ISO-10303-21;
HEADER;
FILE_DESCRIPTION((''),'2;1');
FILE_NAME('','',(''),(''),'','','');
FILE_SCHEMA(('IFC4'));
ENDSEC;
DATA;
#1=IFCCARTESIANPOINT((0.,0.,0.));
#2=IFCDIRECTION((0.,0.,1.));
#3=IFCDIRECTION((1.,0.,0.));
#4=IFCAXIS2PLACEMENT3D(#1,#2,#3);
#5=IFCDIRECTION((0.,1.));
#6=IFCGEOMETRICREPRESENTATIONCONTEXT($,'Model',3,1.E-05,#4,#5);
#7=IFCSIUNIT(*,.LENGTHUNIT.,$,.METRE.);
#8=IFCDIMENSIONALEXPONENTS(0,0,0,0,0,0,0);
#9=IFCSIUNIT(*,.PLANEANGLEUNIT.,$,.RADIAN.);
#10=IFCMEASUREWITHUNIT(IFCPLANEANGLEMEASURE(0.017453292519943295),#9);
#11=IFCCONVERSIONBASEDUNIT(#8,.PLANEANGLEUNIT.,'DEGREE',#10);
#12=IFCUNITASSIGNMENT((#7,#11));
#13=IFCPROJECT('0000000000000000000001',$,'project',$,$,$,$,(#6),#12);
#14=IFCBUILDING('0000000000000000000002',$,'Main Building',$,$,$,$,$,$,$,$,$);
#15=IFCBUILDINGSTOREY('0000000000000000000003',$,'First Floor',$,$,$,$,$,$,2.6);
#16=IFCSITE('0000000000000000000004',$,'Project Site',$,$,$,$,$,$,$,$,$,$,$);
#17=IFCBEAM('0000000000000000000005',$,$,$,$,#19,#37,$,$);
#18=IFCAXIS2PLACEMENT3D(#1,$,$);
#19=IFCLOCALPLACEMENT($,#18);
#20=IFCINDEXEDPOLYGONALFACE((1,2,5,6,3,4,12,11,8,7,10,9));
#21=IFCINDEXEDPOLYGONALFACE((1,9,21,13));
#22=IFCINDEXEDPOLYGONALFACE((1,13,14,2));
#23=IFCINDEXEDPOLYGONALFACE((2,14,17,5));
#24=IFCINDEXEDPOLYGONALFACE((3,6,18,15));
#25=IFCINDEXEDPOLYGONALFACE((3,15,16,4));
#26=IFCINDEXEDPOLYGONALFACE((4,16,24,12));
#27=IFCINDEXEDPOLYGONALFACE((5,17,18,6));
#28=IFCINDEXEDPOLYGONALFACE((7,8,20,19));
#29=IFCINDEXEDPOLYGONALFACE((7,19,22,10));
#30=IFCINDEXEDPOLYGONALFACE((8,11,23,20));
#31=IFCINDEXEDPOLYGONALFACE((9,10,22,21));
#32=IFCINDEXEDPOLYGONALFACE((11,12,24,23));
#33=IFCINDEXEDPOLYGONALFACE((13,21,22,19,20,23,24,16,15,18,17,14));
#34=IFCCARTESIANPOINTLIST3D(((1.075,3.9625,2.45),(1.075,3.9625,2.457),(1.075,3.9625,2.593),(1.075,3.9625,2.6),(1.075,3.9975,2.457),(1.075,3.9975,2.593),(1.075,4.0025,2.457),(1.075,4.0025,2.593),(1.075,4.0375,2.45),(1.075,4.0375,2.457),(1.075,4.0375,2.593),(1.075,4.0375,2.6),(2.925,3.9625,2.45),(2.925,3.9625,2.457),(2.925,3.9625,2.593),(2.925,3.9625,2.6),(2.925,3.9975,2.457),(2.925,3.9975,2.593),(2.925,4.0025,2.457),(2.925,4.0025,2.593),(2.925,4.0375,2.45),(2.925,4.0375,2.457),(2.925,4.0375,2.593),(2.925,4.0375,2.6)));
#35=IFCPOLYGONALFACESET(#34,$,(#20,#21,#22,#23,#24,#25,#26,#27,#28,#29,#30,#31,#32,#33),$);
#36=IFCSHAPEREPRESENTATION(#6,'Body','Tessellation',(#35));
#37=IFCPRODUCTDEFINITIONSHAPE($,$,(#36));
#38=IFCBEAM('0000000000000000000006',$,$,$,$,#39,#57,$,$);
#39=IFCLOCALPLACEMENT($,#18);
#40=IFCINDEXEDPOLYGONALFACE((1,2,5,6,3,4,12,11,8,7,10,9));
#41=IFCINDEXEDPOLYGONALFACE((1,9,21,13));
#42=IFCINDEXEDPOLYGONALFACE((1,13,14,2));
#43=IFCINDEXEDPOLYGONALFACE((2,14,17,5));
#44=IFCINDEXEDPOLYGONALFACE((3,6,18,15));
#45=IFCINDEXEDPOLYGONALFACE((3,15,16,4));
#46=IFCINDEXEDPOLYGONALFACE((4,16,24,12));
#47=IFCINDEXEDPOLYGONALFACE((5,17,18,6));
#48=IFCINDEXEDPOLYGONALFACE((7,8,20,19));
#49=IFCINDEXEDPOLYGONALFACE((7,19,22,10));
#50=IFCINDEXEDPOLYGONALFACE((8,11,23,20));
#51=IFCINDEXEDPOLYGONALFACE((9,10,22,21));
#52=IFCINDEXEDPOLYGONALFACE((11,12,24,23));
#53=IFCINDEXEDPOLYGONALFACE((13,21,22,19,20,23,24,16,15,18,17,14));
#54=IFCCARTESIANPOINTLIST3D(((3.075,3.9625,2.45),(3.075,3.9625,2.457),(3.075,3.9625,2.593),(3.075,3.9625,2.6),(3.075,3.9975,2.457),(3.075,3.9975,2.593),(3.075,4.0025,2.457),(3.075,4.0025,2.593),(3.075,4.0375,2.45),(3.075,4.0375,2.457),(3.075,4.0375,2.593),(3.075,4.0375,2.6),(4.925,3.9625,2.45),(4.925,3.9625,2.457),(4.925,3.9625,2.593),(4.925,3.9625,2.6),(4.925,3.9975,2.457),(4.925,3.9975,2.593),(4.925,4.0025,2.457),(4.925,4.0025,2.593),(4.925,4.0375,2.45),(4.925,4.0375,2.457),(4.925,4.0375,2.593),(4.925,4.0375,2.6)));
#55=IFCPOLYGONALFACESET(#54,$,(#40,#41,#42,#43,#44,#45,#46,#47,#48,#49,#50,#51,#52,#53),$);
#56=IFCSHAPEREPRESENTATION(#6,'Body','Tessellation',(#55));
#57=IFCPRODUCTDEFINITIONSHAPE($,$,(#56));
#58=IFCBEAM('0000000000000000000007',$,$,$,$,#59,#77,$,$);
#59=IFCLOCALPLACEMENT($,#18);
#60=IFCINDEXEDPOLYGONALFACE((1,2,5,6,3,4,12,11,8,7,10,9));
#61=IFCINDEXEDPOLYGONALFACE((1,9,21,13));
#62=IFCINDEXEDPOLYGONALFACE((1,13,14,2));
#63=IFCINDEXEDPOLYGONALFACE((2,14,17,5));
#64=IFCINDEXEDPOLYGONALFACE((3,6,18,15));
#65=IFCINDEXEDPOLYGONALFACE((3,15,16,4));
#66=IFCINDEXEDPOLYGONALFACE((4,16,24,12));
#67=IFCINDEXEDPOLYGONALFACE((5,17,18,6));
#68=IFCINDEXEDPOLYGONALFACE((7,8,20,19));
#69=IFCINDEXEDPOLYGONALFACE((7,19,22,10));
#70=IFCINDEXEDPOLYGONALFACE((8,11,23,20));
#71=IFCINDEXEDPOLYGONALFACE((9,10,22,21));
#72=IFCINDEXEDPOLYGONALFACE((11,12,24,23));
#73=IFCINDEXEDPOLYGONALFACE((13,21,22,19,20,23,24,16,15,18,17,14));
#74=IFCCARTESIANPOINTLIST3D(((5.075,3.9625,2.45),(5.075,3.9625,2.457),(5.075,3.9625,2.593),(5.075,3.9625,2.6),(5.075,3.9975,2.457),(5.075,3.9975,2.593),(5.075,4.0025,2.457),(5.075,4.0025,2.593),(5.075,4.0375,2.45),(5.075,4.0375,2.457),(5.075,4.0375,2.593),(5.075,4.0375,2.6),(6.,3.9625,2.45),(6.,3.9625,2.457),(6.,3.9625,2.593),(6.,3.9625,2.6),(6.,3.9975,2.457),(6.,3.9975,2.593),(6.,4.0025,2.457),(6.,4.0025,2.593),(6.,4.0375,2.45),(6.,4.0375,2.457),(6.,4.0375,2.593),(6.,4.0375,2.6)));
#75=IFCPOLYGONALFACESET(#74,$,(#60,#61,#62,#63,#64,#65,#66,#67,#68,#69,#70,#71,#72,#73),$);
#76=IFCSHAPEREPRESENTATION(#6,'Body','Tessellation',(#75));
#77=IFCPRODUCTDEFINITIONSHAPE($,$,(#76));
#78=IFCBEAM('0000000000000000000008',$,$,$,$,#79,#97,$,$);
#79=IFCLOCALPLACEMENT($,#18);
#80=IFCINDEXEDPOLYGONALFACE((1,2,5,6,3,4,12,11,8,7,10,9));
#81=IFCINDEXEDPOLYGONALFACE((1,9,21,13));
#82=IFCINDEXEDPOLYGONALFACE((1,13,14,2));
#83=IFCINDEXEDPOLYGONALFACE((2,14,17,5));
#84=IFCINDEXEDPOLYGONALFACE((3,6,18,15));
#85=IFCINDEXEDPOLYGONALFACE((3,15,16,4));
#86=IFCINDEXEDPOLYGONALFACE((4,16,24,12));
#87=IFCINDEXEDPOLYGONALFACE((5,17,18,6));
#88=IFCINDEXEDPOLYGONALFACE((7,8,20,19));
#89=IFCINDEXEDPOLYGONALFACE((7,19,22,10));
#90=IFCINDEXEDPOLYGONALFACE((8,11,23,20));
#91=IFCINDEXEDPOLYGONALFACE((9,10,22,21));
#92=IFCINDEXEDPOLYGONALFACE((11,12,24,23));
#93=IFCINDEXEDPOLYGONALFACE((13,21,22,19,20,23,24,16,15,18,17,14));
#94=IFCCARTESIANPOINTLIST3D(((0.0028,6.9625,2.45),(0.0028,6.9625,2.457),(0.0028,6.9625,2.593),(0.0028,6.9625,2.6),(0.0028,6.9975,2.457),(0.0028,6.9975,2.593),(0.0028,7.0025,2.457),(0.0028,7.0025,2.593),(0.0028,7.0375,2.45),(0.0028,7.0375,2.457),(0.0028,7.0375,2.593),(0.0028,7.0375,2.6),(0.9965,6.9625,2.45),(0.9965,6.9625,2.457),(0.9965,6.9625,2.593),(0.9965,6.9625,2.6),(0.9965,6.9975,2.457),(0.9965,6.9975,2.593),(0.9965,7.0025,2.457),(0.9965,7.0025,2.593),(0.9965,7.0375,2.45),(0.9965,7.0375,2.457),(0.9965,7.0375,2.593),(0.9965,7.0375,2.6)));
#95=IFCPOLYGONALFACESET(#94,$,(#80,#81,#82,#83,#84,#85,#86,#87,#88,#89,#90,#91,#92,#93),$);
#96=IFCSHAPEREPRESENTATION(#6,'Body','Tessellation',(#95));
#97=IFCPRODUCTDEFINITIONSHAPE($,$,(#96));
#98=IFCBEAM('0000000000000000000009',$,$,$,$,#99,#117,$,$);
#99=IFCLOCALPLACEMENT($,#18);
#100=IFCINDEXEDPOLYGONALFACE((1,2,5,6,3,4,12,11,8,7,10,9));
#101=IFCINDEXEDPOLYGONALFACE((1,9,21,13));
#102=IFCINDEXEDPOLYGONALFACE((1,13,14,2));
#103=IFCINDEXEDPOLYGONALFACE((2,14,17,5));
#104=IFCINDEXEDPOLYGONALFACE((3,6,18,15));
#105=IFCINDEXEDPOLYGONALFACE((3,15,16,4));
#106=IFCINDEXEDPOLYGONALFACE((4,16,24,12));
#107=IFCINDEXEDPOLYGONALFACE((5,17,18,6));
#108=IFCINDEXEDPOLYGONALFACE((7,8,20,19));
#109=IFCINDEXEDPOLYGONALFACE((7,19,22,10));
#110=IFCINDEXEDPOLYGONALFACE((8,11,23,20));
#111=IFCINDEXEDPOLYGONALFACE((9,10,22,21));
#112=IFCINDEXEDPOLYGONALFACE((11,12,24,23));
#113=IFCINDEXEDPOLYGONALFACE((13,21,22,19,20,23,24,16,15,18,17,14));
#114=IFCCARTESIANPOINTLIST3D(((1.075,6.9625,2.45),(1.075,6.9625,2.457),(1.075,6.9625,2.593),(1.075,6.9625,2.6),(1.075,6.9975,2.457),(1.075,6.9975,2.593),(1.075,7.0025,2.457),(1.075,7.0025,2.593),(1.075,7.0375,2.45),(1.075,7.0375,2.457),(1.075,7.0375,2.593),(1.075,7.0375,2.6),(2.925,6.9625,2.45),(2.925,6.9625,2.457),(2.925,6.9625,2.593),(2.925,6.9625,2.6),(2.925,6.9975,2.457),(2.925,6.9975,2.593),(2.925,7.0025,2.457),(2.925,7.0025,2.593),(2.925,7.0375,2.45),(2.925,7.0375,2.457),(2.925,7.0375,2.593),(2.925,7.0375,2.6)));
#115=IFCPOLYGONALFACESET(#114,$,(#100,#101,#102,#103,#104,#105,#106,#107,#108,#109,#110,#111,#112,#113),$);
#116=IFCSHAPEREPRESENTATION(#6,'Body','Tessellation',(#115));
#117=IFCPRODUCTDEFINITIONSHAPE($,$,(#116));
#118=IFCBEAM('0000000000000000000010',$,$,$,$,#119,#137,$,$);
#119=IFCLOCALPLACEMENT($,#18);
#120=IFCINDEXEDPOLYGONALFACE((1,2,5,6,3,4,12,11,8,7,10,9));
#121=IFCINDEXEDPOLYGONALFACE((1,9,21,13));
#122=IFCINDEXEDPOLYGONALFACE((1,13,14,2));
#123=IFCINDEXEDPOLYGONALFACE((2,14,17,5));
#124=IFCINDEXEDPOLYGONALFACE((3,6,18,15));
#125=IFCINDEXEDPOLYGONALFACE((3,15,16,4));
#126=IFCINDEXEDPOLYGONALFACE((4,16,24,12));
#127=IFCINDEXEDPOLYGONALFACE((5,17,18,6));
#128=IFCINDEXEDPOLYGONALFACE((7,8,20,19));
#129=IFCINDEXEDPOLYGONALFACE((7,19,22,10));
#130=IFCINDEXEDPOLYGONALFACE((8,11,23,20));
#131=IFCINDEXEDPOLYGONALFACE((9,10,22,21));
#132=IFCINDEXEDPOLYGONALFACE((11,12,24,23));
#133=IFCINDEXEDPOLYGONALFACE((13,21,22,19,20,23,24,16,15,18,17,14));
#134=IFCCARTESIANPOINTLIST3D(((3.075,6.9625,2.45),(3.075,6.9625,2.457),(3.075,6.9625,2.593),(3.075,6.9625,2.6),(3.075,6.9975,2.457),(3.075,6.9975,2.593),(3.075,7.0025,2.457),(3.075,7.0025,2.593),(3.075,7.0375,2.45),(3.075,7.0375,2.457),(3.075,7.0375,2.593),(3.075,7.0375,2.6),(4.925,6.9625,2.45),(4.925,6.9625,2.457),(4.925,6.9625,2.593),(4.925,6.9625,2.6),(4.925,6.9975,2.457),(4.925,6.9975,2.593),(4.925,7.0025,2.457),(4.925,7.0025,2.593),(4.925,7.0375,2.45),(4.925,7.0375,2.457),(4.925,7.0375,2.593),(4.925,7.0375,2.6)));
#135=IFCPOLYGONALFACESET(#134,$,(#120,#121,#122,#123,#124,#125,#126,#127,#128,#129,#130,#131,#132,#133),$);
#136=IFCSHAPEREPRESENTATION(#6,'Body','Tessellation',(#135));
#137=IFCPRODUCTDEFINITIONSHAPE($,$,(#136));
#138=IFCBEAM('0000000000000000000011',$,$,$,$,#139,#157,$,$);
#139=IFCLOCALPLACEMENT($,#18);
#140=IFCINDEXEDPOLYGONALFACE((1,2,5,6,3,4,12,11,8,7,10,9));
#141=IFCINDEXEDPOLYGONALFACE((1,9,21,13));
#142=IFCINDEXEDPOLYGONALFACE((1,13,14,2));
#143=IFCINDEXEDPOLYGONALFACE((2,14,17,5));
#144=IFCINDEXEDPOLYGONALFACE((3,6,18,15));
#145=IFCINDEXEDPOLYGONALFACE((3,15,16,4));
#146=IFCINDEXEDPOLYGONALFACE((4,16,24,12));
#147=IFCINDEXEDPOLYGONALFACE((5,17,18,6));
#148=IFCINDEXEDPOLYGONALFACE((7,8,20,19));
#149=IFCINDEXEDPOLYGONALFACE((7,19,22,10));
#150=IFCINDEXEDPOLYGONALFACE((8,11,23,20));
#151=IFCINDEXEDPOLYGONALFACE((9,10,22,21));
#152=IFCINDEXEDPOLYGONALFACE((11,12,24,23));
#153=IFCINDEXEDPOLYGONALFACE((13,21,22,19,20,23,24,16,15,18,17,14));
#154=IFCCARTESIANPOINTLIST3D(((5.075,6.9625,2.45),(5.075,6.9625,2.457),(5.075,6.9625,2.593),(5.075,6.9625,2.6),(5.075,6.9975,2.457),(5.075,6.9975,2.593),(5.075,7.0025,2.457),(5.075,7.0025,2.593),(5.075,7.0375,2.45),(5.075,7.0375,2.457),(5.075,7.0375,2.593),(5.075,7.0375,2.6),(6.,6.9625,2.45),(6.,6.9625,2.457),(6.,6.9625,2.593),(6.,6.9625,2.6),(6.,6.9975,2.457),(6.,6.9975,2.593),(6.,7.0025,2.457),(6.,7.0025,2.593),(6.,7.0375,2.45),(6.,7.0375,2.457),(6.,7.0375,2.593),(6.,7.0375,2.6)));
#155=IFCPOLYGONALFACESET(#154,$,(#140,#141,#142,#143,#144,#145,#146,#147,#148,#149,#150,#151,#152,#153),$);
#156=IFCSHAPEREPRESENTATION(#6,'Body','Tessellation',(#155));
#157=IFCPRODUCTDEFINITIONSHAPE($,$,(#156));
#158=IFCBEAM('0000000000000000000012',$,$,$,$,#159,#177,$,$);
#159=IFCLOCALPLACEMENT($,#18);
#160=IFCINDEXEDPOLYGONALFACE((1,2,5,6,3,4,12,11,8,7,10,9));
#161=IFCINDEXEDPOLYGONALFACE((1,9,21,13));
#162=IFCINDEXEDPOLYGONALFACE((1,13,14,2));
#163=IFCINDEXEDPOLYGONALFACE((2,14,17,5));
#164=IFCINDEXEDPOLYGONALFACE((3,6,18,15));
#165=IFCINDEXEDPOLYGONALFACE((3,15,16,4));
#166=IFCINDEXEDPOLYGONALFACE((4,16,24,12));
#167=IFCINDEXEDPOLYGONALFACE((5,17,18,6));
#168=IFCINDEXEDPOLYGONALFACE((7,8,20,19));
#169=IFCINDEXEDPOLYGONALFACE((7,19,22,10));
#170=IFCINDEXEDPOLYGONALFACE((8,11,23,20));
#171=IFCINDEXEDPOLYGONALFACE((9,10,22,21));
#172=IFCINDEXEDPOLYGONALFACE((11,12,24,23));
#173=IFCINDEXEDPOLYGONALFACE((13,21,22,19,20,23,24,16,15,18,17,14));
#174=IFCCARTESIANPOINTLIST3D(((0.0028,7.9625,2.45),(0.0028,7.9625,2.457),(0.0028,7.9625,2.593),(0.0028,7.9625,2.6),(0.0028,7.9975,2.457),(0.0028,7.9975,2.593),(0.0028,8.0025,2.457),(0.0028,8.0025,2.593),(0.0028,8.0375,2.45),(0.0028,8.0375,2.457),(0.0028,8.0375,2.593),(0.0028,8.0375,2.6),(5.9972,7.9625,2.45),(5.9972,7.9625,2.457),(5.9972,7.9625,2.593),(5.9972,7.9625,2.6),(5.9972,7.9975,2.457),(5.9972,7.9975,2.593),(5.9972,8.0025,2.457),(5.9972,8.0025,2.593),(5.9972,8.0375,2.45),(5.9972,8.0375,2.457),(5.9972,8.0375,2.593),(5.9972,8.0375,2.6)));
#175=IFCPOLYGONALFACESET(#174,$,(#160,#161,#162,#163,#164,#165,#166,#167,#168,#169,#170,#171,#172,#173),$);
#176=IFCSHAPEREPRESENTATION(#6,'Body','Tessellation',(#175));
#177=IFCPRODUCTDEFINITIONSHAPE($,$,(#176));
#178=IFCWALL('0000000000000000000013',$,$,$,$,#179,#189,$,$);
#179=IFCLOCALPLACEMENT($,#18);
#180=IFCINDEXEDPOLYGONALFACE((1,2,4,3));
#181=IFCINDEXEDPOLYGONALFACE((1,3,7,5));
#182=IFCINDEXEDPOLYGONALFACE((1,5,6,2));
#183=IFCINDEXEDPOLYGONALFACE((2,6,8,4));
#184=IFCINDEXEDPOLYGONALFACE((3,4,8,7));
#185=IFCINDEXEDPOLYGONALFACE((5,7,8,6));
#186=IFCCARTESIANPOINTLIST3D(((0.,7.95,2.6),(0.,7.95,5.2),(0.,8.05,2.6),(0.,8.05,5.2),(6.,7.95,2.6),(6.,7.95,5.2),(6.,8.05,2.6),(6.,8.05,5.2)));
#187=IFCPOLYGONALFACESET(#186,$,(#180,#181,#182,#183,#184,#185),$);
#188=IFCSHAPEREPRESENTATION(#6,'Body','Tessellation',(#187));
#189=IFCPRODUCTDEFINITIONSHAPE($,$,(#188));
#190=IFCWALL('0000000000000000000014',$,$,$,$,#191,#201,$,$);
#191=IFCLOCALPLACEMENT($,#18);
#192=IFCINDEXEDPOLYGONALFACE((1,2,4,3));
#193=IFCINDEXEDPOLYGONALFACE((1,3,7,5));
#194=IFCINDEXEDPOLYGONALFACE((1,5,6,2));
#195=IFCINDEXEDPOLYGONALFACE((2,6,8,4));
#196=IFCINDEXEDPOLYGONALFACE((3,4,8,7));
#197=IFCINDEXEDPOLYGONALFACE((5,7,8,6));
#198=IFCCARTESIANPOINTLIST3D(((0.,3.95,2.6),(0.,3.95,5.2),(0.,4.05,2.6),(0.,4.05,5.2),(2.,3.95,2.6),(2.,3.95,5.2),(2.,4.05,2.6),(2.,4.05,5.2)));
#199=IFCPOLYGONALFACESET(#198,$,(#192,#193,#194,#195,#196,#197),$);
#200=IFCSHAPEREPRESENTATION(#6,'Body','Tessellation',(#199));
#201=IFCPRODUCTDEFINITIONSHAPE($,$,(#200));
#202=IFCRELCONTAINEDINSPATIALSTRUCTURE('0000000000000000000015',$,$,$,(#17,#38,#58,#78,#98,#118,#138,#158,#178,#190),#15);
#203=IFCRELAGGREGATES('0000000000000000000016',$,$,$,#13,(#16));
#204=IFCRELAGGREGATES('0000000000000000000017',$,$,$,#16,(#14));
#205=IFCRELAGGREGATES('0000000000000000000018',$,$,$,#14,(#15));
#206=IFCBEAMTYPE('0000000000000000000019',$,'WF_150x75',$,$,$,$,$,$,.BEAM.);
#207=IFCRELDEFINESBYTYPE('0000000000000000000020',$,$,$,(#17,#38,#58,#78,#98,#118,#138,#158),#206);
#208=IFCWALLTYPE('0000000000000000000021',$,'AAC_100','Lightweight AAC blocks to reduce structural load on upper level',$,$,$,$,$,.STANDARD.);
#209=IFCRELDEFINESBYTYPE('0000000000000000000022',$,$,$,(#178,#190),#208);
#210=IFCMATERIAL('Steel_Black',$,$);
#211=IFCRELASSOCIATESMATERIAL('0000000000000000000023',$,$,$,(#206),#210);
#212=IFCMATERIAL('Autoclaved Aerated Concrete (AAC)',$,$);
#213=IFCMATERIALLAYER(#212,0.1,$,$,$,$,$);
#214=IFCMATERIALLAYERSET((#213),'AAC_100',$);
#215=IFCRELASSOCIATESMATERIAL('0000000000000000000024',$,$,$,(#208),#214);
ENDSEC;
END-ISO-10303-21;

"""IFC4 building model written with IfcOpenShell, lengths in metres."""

from ifc_helpers import new_model, entity, si_unit, converted_unit, direction, frame, frame_2d, origin, origin_with_axes, origin_2d, place, context, project, spatial, rectangle, i_section, extrude, material, layer, layer_set, material_profile, profile_set, type_object, element, save


model = new_model("IFC4")

# Units and contexts
model_context = context("Model", 3, precision=1e-05, world=origin_with_axes(), true_north=direction((0.0, 1.0)))
ifc_project = project(units=[si_unit("LENGTHUNIT", "METRE"), converted_unit("PLANEANGLEUNIT", "DEGREE", entity("IfcPlaneAngleMeasure", 0.017453292519943295), si_unit("PLANEANGLEUNIT", "RADIAN"), dimensions=[0, 0, 0, 0, 0, 0, 0])], contexts=[model_context])

# Site, building, storey
site = spatial("IfcSite", under=ifc_project, Name="Project Site")
building = spatial("IfcBuilding", under=site, Name="Main Building")
storey = spatial("IfcBuildingStorey", under=building, Name="First Floor", Elevation=2.6)

# Shared definitions
ifc_material_1 = material(Name="Steel_Black")

# Beams
ifc_material_profile_1 = material_profile(ifc_material_1, i_section(OverallWidth=0.075, OverallDepth=0.15, WebThickness=0.005, FlangeThickness=0.007, at=origin_2d()), Name="WF_150x75")
ifc_profile_set_1 = profile_set([ifc_material_profile_1], Name="WF_150x75")
beam_type_1 = type_object("IfcBeamType", Name="WF_150x75", PredefinedType="BEAM", material=ifc_profile_set_1)
for number, where, z_axis, x_axis in (
    (1, (1.075, 4.0, 2.45), (0.0, 0.0, 1.0), (1.0, 0.0, 0.0)),
    (2, (3.075, 4.0, 2.45), (0.0, 0.0, 1.0), (1.0, 0.0, 0.0)),
):
    element("IfcBeam", number, at=place(None, frame(where, z_axis=z_axis, x_axis=x_axis)), inside=storey, type_object=beam_type_1, context=model_context, shape_type="SweptSolid", body=[
        extrude(i_section(OverallWidth=0.075, OverallDepth=0.15, WebThickness=0.005, FlangeThickness=0.007, at=frame_2d((0.0, 0.075))), frame((0.0, 0.0, 0.0), z_axis=(1.0, 0.0, 0.0), x_axis=(0.0, 1.0, 0.0)), (0.0, 0.0, 1.0), 1.85),
    ])
beam_1_placement = place(None, frame((5.075, 4.0, 2.45), z_axis=(0.0, 0.0, 1.0), x_axis=(1.0, 0.0, 0.0)))
element("IfcBeam", 3, at=beam_1_placement, inside=storey, type_object=beam_type_1, context=model_context, shape_type="SweptSolid", body=[
    extrude(i_section(OverallWidth=0.075, OverallDepth=0.15, WebThickness=0.005, FlangeThickness=0.007, at=frame_2d((0.0, 0.075))), frame((0.0, 0.0, 0.0), z_axis=(1.0, 0.0, 0.0), x_axis=(0.0, 1.0, 0.0)), (0.0, 0.0, 1.0), 0.925),
])
beam_2_placement = place(None, frame((0.0027, 7.0, 2.45), z_axis=(0.0, 0.0, 1.0), x_axis=(1.0, 0.0, 0.0)))
element("IfcBeam", 4, at=beam_2_placement, inside=storey, type_object=beam_type_1, context=model_context, shape_type="SweptSolid", body=[
    extrude(i_section(OverallWidth=0.075, OverallDepth=0.15, WebThickness=0.005, FlangeThickness=0.007, at=frame_2d((0.0, 0.075))), frame((0.0, 0.0, 0.0), z_axis=(1.0, 0.0, 0.0), x_axis=(0.0, 1.0, 0.0)), (0.0, 0.0, 1.0), 0.9938),
])
for number, where, z_axis, x_axis in (
    (5, (1.075, 7.0, 2.45), (0.0, 0.0, 1.0), (1.0, 0.0, 0.0)),
    (6, (3.075, 7.0, 2.45), (0.0, 0.0, 1.0), (1.0, 0.0, 0.0)),
):
    element("IfcBeam", number, at=place(None, frame(where, z_axis=z_axis, x_axis=x_axis)), inside=storey, type_object=beam_type_1, context=model_context, shape_type="SweptSolid", body=[
        extrude(i_section(OverallWidth=0.075, OverallDepth=0.15, WebThickness=0.005, FlangeThickness=0.007, at=frame_2d((0.0, 0.075))), frame((0.0, 0.0, 0.0), z_axis=(1.0, 0.0, 0.0), x_axis=(0.0, 1.0, 0.0)), (0.0, 0.0, 1.0), 1.85),
    ])
beam_3_placement = place(None, frame((5.075, 7.0, 2.45), z_axis=(0.0, 0.0, 1.0), x_axis=(1.0, 0.0, 0.0)))
element("IfcBeam", 7, at=beam_3_placement, inside=storey, type_object=beam_type_1, context=model_context, shape_type="SweptSolid", body=[
    extrude(i_section(OverallWidth=0.075, OverallDepth=0.15, WebThickness=0.005, FlangeThickness=0.007, at=frame_2d((0.0, 0.075))), frame((0.0, 0.0, 0.0), z_axis=(1.0, 0.0, 0.0), x_axis=(0.0, 1.0, 0.0)), (0.0, 0.0, 1.0), 0.925),
])
beam_4_placement = place(None, frame((0.0027, 8.0, 2.45), z_axis=(0.0, 0.0, 1.0), x_axis=(1.0, 0.0, 0.0)))
element("IfcBeam", 8, at=beam_4_placement, inside=storey, type_object=beam_type_1, context=model_context, shape_type="SweptSolid", body=[
    extrude(i_section(OverallWidth=0.075, OverallDepth=0.15, WebThickness=0.005, FlangeThickness=0.007, at=frame_2d((0.0, 0.075))), frame((0.0, 0.0, 0.0), z_axis=(1.0, 0.0, 0.0), x_axis=(0.0, 1.0, 0.0)), (0.0, 0.0, 1.0), 5.9945),
])

# Walls
ifc_material_2 = material(Name="Autoclaved Aerated Concrete (AAC)")
ifc_layer = layer(ifc_material_2, 0.1)
ifc_layer_set = layer_set([ifc_layer], Name="AAC_100")
wall_type = type_object("IfcWallType", Name="AAC_100", Description="Lightweight AAC blocks to reduce structural load on upper level", PredefinedType="STANDARD", material=ifc_layer_set)
wall_1_placement = place(None, frame((0.0, 8.0, 2.6), z_axis=(0.0, 0.0, 1.0), x_axis=(1.0, 0.0, 0.0)))
element("IfcWall", 9, at=wall_1_placement, inside=storey, type_object=wall_type, context=model_context, shape_type="SweptSolid", body=[
    extrude(rectangle(XDim=6.0, YDim=0.1, at=frame_2d((3.0, 0.0))), origin(), (0.0, 0.0, 1.0), 2.6),
])
wall_2_placement = place(None, frame((0.0, 4.0, 2.6), z_axis=(0.0, 0.0, 1.0), x_axis=(1.0, 0.0, 0.0)))
element("IfcWall", 10, at=wall_2_placement, inside=storey, type_object=wall_type, context=model_context, shape_type="SweptSolid", body=[
    extrude(rectangle(XDim=2.0, YDim=0.1, at=frame_2d((1.0, 0.0))), origin(), (0.0, 0.0, 1.0), 2.6),
])

save(model, "model.ifc")
